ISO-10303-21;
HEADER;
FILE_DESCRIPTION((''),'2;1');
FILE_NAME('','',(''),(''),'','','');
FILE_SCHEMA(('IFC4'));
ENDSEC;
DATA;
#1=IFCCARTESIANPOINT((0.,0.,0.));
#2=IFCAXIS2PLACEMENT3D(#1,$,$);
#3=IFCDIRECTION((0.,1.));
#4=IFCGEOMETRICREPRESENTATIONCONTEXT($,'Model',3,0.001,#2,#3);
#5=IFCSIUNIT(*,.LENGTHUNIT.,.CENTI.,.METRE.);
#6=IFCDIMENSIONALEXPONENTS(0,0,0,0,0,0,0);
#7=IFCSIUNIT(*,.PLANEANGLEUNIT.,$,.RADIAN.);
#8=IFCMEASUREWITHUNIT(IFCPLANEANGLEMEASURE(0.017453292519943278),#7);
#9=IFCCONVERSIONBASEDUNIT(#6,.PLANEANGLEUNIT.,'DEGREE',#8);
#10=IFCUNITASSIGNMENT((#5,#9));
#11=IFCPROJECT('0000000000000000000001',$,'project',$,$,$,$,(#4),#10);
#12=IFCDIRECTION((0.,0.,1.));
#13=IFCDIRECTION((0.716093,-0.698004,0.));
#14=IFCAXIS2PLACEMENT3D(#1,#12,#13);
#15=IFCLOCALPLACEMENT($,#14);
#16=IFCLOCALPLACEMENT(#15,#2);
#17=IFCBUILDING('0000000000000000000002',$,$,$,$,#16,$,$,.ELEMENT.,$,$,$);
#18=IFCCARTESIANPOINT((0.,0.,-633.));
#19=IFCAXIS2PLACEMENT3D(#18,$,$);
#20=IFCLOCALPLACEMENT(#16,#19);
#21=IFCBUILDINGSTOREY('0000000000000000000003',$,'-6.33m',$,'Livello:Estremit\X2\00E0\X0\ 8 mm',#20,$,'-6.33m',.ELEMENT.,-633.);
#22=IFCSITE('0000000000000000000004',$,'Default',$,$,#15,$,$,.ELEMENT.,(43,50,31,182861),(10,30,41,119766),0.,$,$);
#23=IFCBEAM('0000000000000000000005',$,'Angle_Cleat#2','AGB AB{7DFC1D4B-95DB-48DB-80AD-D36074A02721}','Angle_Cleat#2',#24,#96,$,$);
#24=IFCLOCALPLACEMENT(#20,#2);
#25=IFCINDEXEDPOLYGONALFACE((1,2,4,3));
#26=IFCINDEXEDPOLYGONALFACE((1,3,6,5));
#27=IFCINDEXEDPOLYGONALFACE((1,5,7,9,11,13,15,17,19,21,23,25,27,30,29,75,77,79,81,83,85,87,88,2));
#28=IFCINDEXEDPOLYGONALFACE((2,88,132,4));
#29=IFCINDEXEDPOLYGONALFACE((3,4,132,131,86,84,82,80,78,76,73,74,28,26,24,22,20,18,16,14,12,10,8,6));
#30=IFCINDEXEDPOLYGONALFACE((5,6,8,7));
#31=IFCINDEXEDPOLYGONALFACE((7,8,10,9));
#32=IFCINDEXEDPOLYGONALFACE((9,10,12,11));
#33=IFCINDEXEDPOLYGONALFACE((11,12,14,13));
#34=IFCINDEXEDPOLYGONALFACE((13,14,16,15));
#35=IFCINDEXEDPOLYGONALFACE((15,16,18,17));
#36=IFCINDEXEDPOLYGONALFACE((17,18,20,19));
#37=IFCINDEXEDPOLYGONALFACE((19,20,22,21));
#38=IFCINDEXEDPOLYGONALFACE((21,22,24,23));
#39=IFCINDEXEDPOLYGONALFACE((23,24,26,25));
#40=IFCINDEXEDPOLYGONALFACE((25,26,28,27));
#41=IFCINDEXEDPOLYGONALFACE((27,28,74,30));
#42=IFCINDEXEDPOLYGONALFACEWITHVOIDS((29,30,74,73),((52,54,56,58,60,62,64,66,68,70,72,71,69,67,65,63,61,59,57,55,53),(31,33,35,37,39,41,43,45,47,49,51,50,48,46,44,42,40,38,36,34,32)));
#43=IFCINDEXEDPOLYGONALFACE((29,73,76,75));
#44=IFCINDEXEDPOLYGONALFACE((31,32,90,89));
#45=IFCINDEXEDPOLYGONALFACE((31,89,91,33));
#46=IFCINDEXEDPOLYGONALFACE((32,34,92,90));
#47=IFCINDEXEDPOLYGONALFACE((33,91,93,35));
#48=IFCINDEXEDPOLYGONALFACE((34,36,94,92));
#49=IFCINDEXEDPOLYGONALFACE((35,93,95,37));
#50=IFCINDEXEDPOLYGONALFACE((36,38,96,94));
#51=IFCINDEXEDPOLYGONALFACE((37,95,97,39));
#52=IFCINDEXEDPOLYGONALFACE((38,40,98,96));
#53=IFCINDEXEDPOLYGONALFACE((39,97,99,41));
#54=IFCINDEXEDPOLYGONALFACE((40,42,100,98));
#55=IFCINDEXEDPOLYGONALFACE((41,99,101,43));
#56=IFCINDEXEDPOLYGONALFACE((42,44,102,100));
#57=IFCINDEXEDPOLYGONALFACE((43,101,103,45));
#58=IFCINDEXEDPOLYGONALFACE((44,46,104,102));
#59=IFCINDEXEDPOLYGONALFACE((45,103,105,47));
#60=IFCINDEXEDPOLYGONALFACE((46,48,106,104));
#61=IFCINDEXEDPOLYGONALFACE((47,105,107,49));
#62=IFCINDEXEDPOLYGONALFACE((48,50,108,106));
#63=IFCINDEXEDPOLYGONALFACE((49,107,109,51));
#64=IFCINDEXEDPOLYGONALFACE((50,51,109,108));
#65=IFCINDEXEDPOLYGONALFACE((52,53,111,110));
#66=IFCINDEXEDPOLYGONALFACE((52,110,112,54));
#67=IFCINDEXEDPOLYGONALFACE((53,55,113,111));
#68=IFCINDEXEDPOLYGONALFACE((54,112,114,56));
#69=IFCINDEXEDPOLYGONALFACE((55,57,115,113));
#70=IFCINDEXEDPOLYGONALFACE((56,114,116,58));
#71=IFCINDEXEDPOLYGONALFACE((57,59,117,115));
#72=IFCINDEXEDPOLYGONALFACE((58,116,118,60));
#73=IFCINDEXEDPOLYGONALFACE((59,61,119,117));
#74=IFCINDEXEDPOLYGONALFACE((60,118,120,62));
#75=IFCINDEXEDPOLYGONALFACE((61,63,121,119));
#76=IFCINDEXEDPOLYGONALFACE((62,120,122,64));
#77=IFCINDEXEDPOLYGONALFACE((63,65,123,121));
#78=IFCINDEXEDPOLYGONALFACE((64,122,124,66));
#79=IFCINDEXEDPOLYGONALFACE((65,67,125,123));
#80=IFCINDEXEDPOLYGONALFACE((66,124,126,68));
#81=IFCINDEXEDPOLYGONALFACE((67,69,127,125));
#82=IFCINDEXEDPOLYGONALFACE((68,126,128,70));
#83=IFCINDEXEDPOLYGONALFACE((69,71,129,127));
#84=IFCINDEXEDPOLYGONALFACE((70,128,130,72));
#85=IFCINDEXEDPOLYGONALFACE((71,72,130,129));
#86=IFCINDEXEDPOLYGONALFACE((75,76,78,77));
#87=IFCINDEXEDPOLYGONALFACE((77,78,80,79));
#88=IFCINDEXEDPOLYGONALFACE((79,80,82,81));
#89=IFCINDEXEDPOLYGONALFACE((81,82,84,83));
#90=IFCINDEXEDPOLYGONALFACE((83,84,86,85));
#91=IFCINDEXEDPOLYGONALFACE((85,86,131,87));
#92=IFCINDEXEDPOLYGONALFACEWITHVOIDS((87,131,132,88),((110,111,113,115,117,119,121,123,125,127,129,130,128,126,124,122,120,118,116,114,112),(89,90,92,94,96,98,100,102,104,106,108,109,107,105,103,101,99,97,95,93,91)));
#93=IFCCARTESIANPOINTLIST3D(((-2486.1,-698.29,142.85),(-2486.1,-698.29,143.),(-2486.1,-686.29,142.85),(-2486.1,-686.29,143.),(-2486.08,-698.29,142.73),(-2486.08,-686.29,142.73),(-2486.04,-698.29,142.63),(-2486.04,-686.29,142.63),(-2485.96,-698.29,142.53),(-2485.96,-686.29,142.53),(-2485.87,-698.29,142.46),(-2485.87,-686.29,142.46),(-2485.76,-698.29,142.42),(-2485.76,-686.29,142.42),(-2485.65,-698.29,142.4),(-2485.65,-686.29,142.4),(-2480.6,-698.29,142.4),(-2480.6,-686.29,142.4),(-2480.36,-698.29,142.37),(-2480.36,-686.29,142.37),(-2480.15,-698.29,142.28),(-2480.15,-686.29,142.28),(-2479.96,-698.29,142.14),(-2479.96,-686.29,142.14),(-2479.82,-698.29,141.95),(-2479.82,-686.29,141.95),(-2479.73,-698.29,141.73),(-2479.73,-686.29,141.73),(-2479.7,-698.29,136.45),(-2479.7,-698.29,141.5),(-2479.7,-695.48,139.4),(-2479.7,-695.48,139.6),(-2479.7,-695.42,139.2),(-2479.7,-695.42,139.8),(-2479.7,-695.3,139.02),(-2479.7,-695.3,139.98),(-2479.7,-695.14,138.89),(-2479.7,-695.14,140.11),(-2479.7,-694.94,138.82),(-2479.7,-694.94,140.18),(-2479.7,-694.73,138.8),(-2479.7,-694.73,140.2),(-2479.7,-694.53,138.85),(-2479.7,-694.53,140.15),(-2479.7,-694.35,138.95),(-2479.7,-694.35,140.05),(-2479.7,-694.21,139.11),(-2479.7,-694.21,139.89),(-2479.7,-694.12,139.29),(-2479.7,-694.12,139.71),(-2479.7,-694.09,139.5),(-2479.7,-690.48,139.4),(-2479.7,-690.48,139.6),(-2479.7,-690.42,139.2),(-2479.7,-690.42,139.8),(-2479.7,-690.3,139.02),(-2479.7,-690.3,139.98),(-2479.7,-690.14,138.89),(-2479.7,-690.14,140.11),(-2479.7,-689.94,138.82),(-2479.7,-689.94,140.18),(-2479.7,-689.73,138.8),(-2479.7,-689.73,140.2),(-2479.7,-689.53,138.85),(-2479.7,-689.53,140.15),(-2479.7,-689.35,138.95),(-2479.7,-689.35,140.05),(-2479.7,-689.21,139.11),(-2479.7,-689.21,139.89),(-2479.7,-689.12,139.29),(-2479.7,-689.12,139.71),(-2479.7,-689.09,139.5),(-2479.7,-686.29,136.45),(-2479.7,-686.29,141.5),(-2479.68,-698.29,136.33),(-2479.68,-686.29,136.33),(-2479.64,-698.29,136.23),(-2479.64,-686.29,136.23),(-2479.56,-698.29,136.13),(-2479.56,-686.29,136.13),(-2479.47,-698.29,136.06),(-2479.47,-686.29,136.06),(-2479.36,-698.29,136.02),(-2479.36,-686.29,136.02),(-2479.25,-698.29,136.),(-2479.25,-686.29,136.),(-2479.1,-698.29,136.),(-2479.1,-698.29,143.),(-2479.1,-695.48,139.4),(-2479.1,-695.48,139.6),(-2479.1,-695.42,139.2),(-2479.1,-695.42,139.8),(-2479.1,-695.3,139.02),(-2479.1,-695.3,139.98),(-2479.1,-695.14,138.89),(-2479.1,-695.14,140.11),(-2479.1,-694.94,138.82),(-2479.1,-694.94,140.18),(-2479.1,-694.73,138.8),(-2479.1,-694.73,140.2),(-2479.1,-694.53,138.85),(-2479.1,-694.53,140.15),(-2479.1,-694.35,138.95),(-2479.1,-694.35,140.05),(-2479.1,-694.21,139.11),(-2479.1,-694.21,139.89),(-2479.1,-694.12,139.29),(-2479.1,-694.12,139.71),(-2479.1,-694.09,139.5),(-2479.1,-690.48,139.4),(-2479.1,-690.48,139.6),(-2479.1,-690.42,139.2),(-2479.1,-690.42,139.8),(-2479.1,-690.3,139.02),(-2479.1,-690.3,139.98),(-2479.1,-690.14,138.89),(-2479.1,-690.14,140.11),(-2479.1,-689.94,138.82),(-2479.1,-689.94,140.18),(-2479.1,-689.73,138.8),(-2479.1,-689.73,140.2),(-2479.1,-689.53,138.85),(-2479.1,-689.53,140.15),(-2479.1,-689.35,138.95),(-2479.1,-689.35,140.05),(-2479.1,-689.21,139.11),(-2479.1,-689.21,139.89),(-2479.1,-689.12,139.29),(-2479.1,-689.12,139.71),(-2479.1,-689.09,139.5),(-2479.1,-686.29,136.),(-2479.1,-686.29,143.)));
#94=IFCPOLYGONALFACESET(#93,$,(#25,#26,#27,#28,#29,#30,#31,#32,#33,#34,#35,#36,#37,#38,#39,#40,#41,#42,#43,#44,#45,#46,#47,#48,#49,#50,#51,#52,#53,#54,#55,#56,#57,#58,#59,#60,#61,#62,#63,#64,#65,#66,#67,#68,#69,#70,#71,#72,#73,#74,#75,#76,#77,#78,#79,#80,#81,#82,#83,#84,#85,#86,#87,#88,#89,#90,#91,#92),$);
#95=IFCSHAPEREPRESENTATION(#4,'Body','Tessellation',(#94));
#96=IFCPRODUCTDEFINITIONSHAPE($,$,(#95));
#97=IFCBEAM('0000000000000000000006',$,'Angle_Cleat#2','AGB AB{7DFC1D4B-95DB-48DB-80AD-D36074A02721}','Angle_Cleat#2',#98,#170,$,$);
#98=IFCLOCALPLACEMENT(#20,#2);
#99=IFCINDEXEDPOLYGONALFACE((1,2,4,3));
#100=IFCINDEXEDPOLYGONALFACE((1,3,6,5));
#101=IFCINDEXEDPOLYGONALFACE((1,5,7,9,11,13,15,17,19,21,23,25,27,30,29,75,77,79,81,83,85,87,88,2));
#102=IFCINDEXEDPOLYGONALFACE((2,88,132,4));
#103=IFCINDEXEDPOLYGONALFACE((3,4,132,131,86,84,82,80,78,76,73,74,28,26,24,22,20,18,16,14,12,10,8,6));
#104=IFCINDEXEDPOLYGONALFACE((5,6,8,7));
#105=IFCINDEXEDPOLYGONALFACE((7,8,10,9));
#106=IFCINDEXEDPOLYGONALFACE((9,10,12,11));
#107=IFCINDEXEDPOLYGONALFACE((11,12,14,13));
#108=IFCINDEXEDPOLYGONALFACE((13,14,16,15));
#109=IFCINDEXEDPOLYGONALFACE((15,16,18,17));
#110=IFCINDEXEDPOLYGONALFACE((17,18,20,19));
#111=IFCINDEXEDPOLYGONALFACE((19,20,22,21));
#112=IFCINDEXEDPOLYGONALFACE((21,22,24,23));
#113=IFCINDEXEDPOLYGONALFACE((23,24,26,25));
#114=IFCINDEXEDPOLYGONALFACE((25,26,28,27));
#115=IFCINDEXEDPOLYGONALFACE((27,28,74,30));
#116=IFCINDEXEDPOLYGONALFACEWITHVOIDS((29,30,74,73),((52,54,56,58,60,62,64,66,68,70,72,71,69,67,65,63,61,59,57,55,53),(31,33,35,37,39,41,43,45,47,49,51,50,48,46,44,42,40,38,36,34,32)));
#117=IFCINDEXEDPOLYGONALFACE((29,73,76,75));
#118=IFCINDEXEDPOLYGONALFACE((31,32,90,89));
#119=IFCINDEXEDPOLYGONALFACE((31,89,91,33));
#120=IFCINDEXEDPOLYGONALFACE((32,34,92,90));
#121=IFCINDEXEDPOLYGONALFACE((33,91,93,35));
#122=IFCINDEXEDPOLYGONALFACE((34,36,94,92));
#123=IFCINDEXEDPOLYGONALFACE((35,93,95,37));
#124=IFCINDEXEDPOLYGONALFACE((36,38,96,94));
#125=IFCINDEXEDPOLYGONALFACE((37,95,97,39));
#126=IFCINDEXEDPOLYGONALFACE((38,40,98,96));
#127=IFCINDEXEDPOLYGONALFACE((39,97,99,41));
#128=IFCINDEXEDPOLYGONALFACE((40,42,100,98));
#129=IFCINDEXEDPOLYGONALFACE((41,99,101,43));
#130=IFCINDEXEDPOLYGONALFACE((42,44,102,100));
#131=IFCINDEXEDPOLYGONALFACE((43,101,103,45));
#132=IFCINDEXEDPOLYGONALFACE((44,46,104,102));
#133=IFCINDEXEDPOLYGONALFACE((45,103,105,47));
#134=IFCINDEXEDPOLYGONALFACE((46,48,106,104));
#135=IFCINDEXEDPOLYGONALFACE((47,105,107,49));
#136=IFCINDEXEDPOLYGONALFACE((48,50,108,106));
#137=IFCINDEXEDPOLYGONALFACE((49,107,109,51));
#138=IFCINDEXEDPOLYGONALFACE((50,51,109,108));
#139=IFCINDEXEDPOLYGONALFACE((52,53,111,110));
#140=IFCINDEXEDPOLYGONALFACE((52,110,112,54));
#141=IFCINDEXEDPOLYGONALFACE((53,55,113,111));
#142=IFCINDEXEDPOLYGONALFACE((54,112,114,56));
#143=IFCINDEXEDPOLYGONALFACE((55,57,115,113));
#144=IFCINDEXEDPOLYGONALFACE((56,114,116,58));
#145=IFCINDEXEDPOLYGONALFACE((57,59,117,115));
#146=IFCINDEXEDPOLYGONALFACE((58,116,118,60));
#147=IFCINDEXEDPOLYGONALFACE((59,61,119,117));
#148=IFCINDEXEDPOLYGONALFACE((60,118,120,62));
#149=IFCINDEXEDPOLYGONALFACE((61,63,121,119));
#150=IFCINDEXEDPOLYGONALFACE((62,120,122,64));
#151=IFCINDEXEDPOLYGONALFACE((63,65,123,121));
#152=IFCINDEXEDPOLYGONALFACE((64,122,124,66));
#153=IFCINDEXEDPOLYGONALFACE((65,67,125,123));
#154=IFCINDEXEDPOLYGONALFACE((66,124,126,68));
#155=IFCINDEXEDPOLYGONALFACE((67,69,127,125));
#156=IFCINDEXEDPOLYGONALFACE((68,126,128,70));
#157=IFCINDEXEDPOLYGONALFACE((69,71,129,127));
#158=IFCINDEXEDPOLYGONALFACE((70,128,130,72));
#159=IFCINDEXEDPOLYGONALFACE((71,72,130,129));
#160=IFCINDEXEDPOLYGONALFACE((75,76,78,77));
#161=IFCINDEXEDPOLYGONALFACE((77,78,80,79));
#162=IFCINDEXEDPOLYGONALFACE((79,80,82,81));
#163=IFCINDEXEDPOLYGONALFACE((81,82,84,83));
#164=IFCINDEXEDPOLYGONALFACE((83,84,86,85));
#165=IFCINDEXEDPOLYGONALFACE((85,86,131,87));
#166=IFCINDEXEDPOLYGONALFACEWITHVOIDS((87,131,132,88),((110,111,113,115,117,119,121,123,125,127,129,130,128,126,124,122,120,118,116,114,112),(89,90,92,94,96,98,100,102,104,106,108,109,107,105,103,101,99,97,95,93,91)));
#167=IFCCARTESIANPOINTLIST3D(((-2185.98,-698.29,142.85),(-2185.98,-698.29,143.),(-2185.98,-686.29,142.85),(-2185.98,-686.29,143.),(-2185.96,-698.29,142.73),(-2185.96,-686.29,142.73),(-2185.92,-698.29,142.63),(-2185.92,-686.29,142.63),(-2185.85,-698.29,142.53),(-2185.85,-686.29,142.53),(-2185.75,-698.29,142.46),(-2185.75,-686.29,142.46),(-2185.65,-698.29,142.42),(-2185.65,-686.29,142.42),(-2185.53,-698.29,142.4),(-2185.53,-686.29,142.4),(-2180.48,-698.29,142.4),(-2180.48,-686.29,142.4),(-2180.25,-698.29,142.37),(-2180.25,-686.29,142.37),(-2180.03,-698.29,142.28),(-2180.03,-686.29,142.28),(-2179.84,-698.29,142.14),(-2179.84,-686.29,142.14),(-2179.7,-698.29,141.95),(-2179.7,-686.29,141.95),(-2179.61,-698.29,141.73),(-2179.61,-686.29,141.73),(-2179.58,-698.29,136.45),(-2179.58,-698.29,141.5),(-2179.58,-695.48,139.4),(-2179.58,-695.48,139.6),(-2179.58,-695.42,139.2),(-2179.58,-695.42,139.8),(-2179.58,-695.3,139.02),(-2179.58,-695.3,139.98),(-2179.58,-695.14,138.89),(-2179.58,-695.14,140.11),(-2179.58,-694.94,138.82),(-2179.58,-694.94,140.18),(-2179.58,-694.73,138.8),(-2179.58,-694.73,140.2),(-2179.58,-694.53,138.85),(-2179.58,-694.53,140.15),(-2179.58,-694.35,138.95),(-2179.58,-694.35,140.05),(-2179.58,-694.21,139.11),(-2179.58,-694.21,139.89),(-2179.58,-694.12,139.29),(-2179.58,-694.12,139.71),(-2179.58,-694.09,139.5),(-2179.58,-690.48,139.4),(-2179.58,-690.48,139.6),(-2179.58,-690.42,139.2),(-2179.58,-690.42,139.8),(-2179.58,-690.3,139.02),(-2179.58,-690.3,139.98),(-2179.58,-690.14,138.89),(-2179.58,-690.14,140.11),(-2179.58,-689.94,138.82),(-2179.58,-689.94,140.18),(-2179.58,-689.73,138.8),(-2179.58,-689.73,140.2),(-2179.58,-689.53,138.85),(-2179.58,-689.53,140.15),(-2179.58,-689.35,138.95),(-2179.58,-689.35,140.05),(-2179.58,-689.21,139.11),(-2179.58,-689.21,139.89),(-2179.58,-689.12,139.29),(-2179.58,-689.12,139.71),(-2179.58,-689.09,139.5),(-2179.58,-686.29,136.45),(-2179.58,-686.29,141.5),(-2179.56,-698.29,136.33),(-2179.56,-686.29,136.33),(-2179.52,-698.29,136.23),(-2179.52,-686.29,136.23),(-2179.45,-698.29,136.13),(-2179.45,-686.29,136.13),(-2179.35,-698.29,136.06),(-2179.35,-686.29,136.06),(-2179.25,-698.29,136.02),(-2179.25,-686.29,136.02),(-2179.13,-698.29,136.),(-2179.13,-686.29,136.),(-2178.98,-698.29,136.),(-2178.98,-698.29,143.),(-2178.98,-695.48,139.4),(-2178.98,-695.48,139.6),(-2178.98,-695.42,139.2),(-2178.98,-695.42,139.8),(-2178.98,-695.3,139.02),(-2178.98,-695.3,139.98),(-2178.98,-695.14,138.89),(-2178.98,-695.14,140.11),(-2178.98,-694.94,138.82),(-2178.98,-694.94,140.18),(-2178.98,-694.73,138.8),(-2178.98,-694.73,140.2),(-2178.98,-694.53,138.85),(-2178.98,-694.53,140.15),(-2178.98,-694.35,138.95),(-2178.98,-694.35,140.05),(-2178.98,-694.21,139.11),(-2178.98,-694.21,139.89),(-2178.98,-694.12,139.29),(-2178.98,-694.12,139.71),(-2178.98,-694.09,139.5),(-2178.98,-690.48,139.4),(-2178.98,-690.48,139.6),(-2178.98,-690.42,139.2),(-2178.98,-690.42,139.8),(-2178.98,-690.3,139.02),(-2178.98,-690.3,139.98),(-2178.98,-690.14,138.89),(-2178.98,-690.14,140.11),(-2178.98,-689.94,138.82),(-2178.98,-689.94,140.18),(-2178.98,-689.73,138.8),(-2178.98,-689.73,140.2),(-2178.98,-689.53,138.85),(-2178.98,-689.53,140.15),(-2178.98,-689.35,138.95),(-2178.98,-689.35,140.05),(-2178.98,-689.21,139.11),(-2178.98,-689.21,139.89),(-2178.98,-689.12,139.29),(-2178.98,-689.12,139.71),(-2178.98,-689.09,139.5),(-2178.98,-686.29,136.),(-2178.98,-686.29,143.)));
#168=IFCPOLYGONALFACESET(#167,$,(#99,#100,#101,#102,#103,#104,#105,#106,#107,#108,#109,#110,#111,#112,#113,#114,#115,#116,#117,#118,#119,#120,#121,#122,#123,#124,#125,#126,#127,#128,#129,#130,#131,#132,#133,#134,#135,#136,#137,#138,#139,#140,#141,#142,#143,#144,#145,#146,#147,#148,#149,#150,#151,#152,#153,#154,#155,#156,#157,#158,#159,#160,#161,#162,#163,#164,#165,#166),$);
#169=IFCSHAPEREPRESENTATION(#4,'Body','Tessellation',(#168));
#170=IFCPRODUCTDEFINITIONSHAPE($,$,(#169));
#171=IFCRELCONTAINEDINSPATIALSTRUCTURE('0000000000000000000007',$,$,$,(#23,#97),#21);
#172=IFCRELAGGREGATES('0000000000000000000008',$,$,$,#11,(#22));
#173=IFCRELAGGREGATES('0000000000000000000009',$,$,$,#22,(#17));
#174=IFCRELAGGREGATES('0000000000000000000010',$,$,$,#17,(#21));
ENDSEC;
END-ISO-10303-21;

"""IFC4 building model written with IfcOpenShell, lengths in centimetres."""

from ifc_helpers import new_model, entity, si_unit, converted_unit, direction, frame, frame_2d, origin, place, context, project, spatial, circle, l_section, extrude, element, save


model = new_model("IFC4")

# Units and contexts
model_context = context("Model", 3, precision=0.001, world=origin(), true_north=direction((0.0, 1.0)))
ifc_project = project(units=[si_unit("LENGTHUNIT", "METRE", prefix="CENTI"), converted_unit("PLANEANGLEUNIT", "DEGREE", entity("IfcPlaneAngleMeasure", 0.017453292519943278), si_unit("PLANEANGLEUNIT", "RADIAN"), dimensions=[0, 0, 0, 0, 0, 0, 0])], contexts=[model_context])

# Site, building, storey
site_placement = place(None, frame((0.0, 0.0, 0.0), z_axis=(0.0, 0.0, 1.0), x_axis=(0.716093, -0.698004, 0.0)))
site = spatial("IfcSite", under=ifc_project, at=site_placement, Name="Default", CompositionType="ELEMENT", RefLatitude=(43, 50, 31, 182861), RefLongitude=(10, 30, 41, 119766), RefElevation=0.0)
building_placement = place(site_placement, origin())
building = spatial("IfcBuilding", under=site, at=building_placement, CompositionType="ELEMENT")
storey_placement = place(building_placement, frame((0.0, 0.0, -633.0)))
storey = spatial("IfcBuildingStorey", under=building, at=storey_placement, Name="-6.33m", ObjectType="Livello:Estremità 8 mm", LongName="-6.33m", CompositionType="ELEMENT", Elevation=-633.0)

# Beams, openings
beam_1_placement = place(storey_placement, frame((-2481.03, -698.29, 141.07), z_axis=(0.0, -1.0, 0.0), x_axis=(-1.0, 0.0, 0.0)))
beam_1 = element("IfcBeam", 1, at=beam_1_placement, inside=storey, Name="Angle_Cleat#2", Description="AGB AB{7DFC1D4B-95DB-48DB-80AD-D36074A02721}", ObjectType="Angle_Cleat#2", context=model_context, shape_type="SweptSolid", body=[
    extrude(l_section(Depth=7.0, Width=7.0, Thickness=0.6, FilletRadius=0.9, EdgeRadius=0.45, at=frame_2d((1.57, 1.57))), origin(), (0.0, 0.0, -1.0), 12.0),
])
opening_1_placement = place(beam_1_placement, frame((-1.28, 1.57, -6.0), z_axis=(-1.0, 0.0, 0.0), x_axis=(0.0, 0.0, -1.0)))
element("IfcOpeningElement", 2, at=opening_1_placement, cuts=beam_1, ObjectType="Opening", context=model_context, shape_type="SweptSolid", body=[
    extrude(circle(Radius=0.7, at=frame_2d((2.5, 0.0), x_axis=(1.0, 0.0))), origin(), (0.0, 0.0, 1.0), 0.7),
])
opening_2_placement = place(beam_1_placement, frame((-1.28, 1.57, -6.0), z_axis=(-1.0, 0.0, 0.0), x_axis=(0.0, 0.0, -1.0)))
element("IfcOpeningElement", 3, at=opening_2_placement, cuts=beam_1, ObjectType="Opening", context=model_context, shape_type="SweptSolid", body=[
    extrude(circle(Radius=0.7, at=frame_2d((-2.5, 0.0), x_axis=(1.0, 0.0))), origin(), (0.0, 0.0, 1.0), 0.7),
])
beam_2_placement = place(storey_placement, frame((-2180.91, -698.29, 141.07), z_axis=(0.0, -1.0, 0.0), x_axis=(-1.0, 0.0, 0.0)))
beam_2 = element("IfcBeam", 4, at=beam_2_placement, inside=storey, Name="Angle_Cleat#2", Description="AGB AB{7DFC1D4B-95DB-48DB-80AD-D36074A02721}", ObjectType="Angle_Cleat#2", context=model_context, shape_type="SweptSolid", body=[
    extrude(l_section(Depth=7.0, Width=7.0, Thickness=0.6, FilletRadius=0.9, EdgeRadius=0.45, at=frame_2d((1.57, 1.57))), origin(), (0.0, 0.0, -1.0), 12.0),
])
opening_3_placement = place(beam_2_placement, frame((-1.28, 1.57, -6.0), z_axis=(-1.0, 0.0, 0.0), x_axis=(0.0, 0.0, -1.0)))
element("IfcOpeningElement", 5, at=opening_3_placement, cuts=beam_2, ObjectType="Opening", context=model_context, shape_type="SweptSolid", body=[
    extrude(circle(Radius=0.7, at=frame_2d((2.5, 0.0), x_axis=(1.0, 0.0))), origin(), (0.0, 0.0, 1.0), 0.7),
])
opening_4_placement = place(beam_2_placement, frame((-1.28, 1.57, -6.0), z_axis=(-1.0, 0.0, 0.0), x_axis=(0.0, 0.0, -1.0)))
element("IfcOpeningElement", 6, at=opening_4_placement, cuts=beam_2, ObjectType="Opening", context=model_context, shape_type="SweptSolid", body=[
    extrude(circle(Radius=0.7, at=frame_2d((-2.5, 0.0), x_axis=(1.0, 0.0))), origin(), (0.0, 0.0, 1.0), 0.7),
])

save(model, "model.ifc")
